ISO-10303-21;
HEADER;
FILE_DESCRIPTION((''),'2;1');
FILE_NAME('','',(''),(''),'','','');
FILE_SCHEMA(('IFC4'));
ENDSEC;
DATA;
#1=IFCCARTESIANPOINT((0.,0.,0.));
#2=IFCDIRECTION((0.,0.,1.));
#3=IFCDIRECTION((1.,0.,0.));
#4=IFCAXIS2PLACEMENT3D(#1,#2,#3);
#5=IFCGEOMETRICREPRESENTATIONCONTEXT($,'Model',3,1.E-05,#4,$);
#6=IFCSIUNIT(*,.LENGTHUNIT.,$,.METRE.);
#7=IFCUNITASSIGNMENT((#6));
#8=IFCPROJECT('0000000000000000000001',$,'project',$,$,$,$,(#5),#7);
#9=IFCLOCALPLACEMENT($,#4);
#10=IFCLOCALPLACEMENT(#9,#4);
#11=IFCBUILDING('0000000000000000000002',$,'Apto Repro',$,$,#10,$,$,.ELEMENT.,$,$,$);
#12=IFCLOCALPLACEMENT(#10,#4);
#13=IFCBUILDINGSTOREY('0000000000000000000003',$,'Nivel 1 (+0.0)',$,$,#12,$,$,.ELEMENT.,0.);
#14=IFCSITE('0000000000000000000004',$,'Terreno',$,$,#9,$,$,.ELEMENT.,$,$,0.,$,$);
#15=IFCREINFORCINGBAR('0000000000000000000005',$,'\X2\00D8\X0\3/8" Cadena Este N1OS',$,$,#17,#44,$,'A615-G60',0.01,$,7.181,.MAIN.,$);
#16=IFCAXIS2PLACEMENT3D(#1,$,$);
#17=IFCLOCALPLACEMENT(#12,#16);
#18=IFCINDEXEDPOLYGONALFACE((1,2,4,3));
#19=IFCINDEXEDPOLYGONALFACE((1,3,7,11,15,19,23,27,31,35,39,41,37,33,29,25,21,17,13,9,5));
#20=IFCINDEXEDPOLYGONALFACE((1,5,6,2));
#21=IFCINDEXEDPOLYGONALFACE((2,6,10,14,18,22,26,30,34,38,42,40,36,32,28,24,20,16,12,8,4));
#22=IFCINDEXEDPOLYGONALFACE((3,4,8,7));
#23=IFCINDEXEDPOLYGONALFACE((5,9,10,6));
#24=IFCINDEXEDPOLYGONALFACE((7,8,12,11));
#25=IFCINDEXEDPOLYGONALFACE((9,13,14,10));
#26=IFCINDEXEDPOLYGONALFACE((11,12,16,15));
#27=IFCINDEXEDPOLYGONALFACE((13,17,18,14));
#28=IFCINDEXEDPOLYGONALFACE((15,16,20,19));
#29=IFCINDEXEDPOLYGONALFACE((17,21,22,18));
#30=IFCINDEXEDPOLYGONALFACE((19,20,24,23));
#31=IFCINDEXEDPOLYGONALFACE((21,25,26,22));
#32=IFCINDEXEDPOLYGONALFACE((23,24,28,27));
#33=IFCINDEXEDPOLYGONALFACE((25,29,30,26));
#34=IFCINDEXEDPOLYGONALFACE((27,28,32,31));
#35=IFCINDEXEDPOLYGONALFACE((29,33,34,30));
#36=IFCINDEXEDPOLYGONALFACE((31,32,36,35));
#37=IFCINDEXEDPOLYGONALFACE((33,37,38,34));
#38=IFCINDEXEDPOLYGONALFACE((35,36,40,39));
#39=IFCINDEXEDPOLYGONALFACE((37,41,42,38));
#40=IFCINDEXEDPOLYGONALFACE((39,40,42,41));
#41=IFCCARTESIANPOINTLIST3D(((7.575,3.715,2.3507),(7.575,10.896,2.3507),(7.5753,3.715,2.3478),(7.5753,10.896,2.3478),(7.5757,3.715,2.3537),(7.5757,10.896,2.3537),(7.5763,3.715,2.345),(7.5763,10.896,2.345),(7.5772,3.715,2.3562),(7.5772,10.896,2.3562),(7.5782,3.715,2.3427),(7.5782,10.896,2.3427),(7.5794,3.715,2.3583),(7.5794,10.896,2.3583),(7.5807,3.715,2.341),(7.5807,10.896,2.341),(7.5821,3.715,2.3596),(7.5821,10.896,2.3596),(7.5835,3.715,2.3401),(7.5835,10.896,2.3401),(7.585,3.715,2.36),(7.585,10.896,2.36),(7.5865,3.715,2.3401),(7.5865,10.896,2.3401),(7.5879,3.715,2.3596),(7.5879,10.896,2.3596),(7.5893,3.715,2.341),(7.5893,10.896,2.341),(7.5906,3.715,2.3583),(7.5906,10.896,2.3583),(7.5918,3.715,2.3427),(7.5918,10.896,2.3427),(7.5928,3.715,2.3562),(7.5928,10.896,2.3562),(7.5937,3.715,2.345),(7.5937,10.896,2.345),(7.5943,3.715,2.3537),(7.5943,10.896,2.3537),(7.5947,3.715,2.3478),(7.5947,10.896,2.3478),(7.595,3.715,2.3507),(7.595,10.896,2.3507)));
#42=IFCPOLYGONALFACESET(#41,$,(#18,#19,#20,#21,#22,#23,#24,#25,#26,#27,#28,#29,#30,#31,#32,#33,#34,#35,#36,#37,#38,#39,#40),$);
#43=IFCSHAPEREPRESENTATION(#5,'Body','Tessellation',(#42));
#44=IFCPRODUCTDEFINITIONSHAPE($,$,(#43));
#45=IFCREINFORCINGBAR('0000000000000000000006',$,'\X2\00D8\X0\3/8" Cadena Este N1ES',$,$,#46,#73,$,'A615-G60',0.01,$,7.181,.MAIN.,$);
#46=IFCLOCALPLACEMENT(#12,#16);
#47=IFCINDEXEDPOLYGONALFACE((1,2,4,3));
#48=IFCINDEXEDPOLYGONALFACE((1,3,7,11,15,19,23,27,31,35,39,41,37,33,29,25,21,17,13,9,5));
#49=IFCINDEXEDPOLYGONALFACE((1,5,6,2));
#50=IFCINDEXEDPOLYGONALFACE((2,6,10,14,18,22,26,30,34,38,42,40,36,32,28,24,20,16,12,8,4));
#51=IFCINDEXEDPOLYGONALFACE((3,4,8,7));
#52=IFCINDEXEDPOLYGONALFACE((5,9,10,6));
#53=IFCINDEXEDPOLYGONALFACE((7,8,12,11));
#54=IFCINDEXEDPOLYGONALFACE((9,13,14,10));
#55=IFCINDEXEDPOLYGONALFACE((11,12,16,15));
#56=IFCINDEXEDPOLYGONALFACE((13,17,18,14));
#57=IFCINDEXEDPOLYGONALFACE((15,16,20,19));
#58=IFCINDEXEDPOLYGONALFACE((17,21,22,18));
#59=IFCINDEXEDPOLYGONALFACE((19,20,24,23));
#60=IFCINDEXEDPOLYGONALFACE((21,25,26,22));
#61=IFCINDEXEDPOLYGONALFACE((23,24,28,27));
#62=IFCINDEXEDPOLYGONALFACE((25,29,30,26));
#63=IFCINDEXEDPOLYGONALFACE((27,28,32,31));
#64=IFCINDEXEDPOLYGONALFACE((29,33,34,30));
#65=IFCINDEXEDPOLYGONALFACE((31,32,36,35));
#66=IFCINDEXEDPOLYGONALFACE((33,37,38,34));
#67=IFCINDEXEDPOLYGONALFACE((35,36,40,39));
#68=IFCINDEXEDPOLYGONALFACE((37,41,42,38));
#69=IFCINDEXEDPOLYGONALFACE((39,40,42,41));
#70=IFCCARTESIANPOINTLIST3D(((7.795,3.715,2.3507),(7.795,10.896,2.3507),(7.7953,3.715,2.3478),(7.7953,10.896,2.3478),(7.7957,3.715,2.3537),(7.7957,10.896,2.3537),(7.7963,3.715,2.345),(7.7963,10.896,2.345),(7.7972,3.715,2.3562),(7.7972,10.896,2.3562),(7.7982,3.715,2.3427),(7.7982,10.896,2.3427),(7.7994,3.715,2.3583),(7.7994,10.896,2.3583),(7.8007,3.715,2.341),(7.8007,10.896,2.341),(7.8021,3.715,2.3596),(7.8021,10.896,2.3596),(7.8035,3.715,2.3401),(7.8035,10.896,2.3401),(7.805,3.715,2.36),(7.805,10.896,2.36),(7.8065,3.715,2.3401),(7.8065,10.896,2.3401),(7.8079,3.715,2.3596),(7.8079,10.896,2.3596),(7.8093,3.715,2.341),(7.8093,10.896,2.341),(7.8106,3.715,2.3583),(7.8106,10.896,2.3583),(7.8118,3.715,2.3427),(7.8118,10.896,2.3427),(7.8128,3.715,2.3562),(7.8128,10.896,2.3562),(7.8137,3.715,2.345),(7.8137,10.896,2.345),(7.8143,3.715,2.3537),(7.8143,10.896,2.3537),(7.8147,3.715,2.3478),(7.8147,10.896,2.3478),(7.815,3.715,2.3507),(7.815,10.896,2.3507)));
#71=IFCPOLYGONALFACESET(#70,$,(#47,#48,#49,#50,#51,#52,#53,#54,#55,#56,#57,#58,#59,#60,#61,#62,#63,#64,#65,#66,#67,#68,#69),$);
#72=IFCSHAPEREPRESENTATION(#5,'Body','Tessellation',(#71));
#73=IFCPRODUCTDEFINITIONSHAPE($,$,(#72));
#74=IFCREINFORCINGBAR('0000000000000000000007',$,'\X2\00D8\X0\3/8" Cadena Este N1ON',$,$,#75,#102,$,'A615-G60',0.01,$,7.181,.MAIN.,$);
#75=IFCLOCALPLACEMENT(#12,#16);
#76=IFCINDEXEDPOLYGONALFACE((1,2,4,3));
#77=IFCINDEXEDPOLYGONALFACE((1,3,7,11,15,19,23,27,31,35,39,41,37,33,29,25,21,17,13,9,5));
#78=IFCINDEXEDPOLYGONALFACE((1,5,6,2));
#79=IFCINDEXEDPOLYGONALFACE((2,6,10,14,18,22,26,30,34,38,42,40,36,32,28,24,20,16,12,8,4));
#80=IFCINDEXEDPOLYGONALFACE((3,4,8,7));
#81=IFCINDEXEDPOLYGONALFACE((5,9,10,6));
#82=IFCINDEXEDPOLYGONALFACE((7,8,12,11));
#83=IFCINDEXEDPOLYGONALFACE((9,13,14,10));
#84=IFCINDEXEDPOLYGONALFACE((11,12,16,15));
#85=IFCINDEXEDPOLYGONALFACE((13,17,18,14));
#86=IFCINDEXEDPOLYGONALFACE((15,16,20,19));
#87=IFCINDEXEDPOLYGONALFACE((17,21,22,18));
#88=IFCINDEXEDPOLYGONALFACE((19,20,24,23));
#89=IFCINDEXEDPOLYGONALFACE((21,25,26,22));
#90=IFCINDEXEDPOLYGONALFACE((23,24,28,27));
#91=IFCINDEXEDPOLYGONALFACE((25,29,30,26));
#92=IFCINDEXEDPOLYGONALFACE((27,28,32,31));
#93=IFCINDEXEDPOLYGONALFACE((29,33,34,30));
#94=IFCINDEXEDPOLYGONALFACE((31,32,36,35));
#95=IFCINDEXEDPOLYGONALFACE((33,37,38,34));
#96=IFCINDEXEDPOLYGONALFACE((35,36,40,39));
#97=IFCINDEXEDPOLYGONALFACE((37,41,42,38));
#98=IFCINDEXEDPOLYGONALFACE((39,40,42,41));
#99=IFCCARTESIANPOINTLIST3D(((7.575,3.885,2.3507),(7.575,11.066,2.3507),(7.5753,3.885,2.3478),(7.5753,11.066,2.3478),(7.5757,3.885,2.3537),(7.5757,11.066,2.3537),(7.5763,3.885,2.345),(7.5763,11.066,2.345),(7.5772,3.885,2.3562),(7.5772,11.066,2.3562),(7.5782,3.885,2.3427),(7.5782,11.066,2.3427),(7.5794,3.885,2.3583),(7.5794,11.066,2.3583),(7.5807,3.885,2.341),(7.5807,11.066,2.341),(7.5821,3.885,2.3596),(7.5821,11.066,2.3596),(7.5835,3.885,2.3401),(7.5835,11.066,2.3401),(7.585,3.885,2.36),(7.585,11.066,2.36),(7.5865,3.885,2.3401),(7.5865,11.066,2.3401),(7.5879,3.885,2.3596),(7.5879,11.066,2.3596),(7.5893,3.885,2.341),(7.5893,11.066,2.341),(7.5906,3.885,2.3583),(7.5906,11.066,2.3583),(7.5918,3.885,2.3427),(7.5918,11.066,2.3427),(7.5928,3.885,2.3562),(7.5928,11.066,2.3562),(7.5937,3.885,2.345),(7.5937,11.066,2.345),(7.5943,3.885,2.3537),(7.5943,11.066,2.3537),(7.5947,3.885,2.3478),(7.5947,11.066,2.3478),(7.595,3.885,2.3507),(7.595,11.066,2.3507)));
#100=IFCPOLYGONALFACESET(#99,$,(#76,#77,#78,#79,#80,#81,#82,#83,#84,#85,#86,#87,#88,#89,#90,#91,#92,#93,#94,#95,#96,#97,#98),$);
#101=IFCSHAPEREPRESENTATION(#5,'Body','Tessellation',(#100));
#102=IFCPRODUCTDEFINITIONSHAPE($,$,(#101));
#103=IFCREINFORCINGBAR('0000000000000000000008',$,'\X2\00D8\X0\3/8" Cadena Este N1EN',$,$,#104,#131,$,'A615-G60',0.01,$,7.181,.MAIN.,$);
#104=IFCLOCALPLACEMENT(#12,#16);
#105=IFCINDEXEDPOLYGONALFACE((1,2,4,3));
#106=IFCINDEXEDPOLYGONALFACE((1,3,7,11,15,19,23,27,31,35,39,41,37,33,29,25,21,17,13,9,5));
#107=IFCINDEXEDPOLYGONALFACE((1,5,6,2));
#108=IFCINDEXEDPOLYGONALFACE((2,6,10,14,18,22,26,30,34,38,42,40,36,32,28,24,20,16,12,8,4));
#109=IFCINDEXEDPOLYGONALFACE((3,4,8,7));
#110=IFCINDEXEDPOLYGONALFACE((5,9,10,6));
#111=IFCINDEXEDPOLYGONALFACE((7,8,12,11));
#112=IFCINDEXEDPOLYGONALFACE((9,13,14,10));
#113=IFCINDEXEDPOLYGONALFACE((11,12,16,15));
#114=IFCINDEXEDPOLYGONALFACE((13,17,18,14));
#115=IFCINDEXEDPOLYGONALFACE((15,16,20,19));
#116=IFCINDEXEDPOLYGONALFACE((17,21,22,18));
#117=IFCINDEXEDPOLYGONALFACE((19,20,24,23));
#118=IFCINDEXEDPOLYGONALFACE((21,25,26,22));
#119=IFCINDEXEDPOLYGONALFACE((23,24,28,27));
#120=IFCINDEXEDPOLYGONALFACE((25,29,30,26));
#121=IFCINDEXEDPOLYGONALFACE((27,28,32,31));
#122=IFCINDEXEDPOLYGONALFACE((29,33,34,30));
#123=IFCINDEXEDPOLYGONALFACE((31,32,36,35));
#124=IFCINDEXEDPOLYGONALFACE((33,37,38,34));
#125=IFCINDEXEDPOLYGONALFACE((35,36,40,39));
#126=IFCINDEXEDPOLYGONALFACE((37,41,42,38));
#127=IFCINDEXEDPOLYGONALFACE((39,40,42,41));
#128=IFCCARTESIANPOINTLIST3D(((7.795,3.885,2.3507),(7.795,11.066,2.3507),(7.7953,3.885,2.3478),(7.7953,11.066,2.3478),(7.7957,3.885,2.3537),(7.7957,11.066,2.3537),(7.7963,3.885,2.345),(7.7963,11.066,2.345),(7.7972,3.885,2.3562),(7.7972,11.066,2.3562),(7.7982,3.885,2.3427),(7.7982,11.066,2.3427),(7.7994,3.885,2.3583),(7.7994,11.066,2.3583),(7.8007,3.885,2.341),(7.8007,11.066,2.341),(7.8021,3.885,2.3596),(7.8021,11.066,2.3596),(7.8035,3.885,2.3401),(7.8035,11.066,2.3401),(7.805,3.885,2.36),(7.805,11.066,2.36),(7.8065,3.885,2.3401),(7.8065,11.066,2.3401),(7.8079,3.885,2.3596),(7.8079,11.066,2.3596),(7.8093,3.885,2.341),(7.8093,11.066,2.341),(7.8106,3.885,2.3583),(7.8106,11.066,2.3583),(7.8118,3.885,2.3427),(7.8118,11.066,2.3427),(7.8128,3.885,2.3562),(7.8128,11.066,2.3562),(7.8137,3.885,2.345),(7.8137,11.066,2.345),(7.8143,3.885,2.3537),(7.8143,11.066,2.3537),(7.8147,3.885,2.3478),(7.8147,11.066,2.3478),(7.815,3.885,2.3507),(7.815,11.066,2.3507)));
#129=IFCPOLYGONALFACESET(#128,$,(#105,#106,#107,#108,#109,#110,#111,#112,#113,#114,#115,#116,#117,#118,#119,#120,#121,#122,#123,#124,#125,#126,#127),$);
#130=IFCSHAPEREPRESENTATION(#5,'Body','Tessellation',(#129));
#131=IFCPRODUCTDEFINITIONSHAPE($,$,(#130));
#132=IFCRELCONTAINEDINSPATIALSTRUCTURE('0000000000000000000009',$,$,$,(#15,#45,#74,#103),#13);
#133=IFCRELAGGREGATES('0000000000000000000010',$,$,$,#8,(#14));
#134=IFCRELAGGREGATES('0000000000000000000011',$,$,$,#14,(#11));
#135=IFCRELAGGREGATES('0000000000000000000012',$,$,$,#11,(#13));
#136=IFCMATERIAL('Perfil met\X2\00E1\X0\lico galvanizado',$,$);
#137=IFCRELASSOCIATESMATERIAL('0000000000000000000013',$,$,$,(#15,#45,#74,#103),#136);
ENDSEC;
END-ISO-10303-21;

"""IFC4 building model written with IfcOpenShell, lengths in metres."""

from ifc_helpers import new_model, si_unit, frame, origin_with_axes, origin_2d_with_axis, place, context, project, spatial, circle, extrude, material, element, save


model = new_model("IFC4")

# Units and contexts
model_context = context("Model", 3, precision=1e-05, world=origin_with_axes())
ifc_project = project(units=[si_unit("LENGTHUNIT", "METRE")], contexts=[model_context])

# Site, building, storey
site_placement = place(None, origin_with_axes())
site = spatial("IfcSite", under=ifc_project, at=site_placement, Name="Terreno", CompositionType="ELEMENT", RefElevation=0.0)
building_placement = place(site_placement, origin_with_axes())
building = spatial("IfcBuilding", under=site, at=building_placement, Name="Apto Repro", CompositionType="ELEMENT")
storey_placement = place(building_placement, origin_with_axes())
storey = spatial("IfcBuildingStorey", under=building, at=storey_placement, Name="Nivel 1 (+0.0)", CompositionType="ELEMENT", Elevation=0.0)

# Reinforcing bars
ifc_material = material(Name="Perfil metálico galvanizado")
reinforcing_bar_1_placement = place(storey_placement, origin_with_axes())
element("IfcReinforcingBar", 1, at=reinforcing_bar_1_placement, inside=storey, material=ifc_material, Name="Ø3/8\" Cadena Este N1OS", SteelGrade="A615-G60", BarLength=7.181, NominalDiameter=0.01, PredefinedType="MAIN", context=model_context, shape_type="SweptSolid", body=[
    extrude(circle(Radius=0.01, at=origin_2d_with_axis()), frame((7.585, 3.715, 2.35), z_axis=(0.0, 1.0, 0.0), x_axis=(0.0, 0.0, 1.0)), (0.0, 0.0, 1.0), 7.181),
])
reinforcing_bar_2_placement = place(storey_placement, origin_with_axes())
element("IfcReinforcingBar", 2, at=reinforcing_bar_2_placement, inside=storey, material=ifc_material, Name="Ø3/8\" Cadena Este N1ES", SteelGrade="A615-G60", BarLength=7.181, NominalDiameter=0.01, PredefinedType="MAIN", context=model_context, shape_type="SweptSolid", body=[
    extrude(circle(Radius=0.01, at=origin_2d_with_axis()), frame((7.805, 3.715, 2.35), z_axis=(0.0, 1.0, 0.0), x_axis=(0.0, 0.0, 1.0)), (0.0, 0.0, 1.0), 7.181),
])
reinforcing_bar_3_placement = place(storey_placement, origin_with_axes())
element("IfcReinforcingBar", 3, at=reinforcing_bar_3_placement, inside=storey, material=ifc_material, Name="Ø3/8\" Cadena Este N1ON", SteelGrade="A615-G60", BarLength=7.181, NominalDiameter=0.01, PredefinedType="MAIN", context=model_context, shape_type="SweptSolid", body=[
    extrude(circle(Radius=0.01, at=origin_2d_with_axis()), frame((7.585, 3.885, 2.35), z_axis=(0.0, 1.0, 0.0), x_axis=(0.0, 0.0, 1.0)), (0.0, 0.0, 1.0), 7.181),
])
reinforcing_bar_4_placement = place(storey_placement, origin_with_axes())
element("IfcReinforcingBar", 4, at=reinforcing_bar_4_placement, inside=storey, material=ifc_material, Name="Ø3/8\" Cadena Este N1EN", SteelGrade="A615-G60", BarLength=7.181, NominalDiameter=0.01, PredefinedType="MAIN", context=model_context, shape_type="SweptSolid", body=[
    extrude(circle(Radius=0.01, at=origin_2d_with_axis()), frame((7.805, 3.885, 2.35), z_axis=(0.0, 1.0, 0.0), x_axis=(0.0, 0.0, 1.0)), (0.0, 0.0, 1.0), 7.181),
])

save(model, "model.ifc")
